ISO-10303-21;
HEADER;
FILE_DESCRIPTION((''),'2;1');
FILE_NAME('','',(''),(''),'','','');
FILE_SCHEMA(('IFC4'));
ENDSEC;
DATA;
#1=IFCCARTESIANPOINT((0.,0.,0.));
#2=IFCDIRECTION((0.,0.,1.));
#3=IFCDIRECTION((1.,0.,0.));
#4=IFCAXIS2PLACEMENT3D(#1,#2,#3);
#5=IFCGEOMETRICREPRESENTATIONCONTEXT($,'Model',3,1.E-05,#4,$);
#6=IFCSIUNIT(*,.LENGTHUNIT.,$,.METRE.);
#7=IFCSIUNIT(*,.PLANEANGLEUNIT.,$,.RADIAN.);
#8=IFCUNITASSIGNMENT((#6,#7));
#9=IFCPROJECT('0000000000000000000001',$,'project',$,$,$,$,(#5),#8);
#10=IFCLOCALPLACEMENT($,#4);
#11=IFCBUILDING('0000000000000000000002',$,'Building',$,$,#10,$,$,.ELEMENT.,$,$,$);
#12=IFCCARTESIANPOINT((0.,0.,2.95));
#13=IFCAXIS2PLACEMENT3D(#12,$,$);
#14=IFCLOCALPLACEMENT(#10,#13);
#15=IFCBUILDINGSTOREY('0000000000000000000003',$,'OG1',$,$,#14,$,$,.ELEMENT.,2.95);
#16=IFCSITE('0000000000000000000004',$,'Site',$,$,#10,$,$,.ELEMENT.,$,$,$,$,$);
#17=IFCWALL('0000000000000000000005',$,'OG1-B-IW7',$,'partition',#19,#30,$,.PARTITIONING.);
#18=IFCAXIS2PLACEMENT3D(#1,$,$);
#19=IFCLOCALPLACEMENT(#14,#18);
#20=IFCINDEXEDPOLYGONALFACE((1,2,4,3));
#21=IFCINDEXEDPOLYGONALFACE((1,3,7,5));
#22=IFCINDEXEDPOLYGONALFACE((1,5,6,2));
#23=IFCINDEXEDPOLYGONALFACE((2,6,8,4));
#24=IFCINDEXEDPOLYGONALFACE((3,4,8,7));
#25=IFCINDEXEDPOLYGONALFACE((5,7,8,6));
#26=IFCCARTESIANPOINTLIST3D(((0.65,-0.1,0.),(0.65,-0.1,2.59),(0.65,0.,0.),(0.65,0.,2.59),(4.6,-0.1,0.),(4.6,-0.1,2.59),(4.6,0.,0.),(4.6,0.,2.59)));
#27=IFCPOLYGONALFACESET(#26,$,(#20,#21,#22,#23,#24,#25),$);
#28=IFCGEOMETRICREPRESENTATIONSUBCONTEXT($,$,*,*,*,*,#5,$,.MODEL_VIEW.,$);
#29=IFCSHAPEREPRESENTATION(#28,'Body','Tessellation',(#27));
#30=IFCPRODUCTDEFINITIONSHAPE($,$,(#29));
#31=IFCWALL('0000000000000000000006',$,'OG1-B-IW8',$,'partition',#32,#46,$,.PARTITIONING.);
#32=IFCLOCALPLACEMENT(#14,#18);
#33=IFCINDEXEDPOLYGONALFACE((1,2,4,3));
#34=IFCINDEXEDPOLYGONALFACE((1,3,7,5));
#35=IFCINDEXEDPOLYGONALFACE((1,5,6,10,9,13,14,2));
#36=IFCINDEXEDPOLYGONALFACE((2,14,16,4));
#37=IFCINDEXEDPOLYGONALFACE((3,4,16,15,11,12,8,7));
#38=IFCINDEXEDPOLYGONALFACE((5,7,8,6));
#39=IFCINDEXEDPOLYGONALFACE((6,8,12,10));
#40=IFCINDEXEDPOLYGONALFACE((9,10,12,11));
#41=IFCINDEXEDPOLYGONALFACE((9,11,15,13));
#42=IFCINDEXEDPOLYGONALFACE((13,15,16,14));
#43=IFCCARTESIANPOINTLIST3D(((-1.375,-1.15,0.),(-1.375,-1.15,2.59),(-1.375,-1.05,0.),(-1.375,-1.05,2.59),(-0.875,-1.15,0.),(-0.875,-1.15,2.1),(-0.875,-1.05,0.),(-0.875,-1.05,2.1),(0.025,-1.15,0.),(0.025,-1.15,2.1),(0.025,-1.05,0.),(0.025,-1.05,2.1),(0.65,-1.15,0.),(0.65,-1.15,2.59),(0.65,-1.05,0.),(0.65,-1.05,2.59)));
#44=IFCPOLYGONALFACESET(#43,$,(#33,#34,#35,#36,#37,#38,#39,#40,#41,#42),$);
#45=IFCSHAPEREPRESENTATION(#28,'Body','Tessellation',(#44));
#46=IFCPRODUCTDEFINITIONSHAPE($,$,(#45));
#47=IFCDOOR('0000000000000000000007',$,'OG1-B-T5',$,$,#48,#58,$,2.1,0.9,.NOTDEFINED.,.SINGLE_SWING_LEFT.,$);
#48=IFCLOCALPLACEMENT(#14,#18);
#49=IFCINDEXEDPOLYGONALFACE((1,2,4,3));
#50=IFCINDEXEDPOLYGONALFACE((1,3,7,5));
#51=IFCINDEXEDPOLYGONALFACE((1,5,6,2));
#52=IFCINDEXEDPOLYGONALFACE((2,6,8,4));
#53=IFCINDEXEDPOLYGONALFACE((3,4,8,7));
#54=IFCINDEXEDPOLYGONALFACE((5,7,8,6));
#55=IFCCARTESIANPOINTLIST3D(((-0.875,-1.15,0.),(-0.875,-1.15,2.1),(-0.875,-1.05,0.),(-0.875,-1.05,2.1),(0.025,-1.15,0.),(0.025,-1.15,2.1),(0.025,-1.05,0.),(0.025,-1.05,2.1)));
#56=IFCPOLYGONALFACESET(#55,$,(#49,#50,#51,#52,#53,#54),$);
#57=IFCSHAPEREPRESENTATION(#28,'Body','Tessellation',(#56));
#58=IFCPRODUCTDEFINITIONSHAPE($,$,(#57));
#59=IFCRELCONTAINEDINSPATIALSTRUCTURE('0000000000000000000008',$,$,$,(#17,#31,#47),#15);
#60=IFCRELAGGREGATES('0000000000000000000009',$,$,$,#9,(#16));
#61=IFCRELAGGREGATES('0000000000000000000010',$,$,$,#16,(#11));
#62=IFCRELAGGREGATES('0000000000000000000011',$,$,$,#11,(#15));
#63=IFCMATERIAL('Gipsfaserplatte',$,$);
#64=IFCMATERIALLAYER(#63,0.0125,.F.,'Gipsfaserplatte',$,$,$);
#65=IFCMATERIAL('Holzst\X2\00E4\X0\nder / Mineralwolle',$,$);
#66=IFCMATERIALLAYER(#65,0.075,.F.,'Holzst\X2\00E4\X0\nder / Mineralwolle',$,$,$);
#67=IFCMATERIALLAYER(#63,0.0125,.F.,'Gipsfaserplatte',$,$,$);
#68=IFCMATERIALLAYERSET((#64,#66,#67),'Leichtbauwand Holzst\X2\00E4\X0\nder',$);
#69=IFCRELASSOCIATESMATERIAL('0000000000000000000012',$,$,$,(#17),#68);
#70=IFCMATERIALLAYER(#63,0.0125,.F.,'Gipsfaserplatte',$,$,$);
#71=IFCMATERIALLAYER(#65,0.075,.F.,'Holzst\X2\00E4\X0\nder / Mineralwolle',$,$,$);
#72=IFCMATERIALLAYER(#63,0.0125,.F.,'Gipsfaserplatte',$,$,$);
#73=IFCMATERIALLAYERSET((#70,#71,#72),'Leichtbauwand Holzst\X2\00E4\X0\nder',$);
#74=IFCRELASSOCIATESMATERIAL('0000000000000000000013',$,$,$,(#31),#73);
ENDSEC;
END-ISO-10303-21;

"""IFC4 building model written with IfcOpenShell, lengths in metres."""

from ifc_helpers import new_model, si_unit, frame, frame_2d, origin, origin_with_axes, place, context, subcontext, project, spatial, rectangle, extrude, material, layer, layer_set, element, fill, save


model = new_model("IFC4")

# Units and contexts
model_context = context("Model", 3, precision=1e-05, world=origin_with_axes())
sub_context = subcontext(model_context, None, None, "MODEL_VIEW")
ifc_project = project(units=[si_unit("LENGTHUNIT", "METRE"), si_unit("PLANEANGLEUNIT", "RADIAN")], contexts=[model_context])

# Site, building, storey
placement = place(None, origin_with_axes())
site = spatial("IfcSite", under=ifc_project, at=placement, Name="Site", CompositionType="ELEMENT")
building = spatial("IfcBuilding", under=site, at=placement, Name="Building", CompositionType="ELEMENT")
storey_placement = place(placement, frame((0.0, 0.0, 2.95)))
storey = spatial("IfcBuildingStorey", under=building, at=storey_placement, Name="OG1", CompositionType="ELEMENT", Elevation=2.95)

# Shared definitions
ifc_material_1 = material(Name="Gipsfaserplatte")

# Wall
ifc_material_2 = material(Name="Holzständer / Mineralwolle")
ifc_layer_1 = layer(ifc_material_1, 0.0125, ventilated=False, Name="Gipsfaserplatte")
ifc_layer_2 = layer(ifc_material_2, 0.075, ventilated=False, Name="Holzständer / Mineralwolle")
ifc_layer_3 = layer(ifc_material_1, 0.0125, ventilated=False, Name="Gipsfaserplatte")
ifc_layer_set_1 = layer_set([ifc_layer_1, ifc_layer_2, ifc_layer_3], Name="Leichtbauwand Holzständer")
wall_1_placement = place(storey_placement, frame((0.65, -0.05, 0.0), z_axis=(0.0, 0.0, 1.0), x_axis=(1.0, 0.0, 0.0)))
element("IfcWall", 1, at=wall_1_placement, inside=storey, material=ifc_layer_set_1, Name="OG1-B-IW7", ObjectType="partition", PredefinedType="PARTITIONING", context=sub_context, shape_type="SweptSolid", body=[
    extrude(rectangle(XDim=3.95, YDim=0.1, at=frame_2d((1.975, 0.0))), origin(), (0.0, 0.0, 1.0), 2.59),
])

# Wall, opening, door
ifc_layer_4 = layer(ifc_material_1, 0.0125, ventilated=False, Name="Gipsfaserplatte")
ifc_layer_5 = layer(ifc_material_2, 0.075, ventilated=False, Name="Holzständer / Mineralwolle")
ifc_layer_6 = layer(ifc_material_1, 0.0125, ventilated=False, Name="Gipsfaserplatte")
ifc_layer_set_2 = layer_set([ifc_layer_4, ifc_layer_5, ifc_layer_6], Name="Leichtbauwand Holzständer")
wall_2_placement = place(storey_placement, frame((-1.375, -1.1, 0.0), z_axis=(0.0, 0.0, 1.0), x_axis=(1.0, 0.0, 0.0)))
wall_2 = element("IfcWall", 2, at=wall_2_placement, inside=storey, material=ifc_layer_set_2, Name="OG1-B-IW8", ObjectType="partition", PredefinedType="PARTITIONING", context=sub_context, shape_type="SweptSolid", body=[
    extrude(rectangle(XDim=2.025, YDim=0.1, at=frame_2d((1.0125, 0.0))), origin(), (0.0, 0.0, 1.0), 2.59),
])
opening_1_placement = place(wall_2_placement, frame((0.95, 0.1, 0.0), z_axis=(0.0, -1.0, 0.0), x_axis=(1.0, 0.0, 0.0)))
opening_1 = element("IfcOpeningElement", 3, at=opening_1_placement, cuts=wall_2, PredefinedType="OPENING", context=sub_context, shape_type="SweptSolid", body=[
    extrude(rectangle(XDim=0.9, YDim=2.1, at=frame_2d((0.0, 1.05))), origin(), (0.0, 0.0, 1.0), 0.2),
])
door_1_placement = place(wall_2_placement, frame((0.95, 0.05, 0.0), z_axis=(0.0, -1.0, 0.0), x_axis=(1.0, 0.0, 0.0)))
door_1 = element("IfcDoor", 4, at=door_1_placement, inside=storey, Name="OG1-B-T5", OperationType="SINGLE_SWING_LEFT", OverallHeight=2.1, OverallWidth=0.9, PredefinedType="NOTDEFINED", context=sub_context, shape_type="SweptSolid", body=[
    extrude(rectangle(XDim=0.9, YDim=2.1, at=frame_2d((0.0, 1.05))), origin(), (0.0, 0.0, 1.0), 0.1),
])
fill(opening_1, door_1)

save(model, "model.ifc")
